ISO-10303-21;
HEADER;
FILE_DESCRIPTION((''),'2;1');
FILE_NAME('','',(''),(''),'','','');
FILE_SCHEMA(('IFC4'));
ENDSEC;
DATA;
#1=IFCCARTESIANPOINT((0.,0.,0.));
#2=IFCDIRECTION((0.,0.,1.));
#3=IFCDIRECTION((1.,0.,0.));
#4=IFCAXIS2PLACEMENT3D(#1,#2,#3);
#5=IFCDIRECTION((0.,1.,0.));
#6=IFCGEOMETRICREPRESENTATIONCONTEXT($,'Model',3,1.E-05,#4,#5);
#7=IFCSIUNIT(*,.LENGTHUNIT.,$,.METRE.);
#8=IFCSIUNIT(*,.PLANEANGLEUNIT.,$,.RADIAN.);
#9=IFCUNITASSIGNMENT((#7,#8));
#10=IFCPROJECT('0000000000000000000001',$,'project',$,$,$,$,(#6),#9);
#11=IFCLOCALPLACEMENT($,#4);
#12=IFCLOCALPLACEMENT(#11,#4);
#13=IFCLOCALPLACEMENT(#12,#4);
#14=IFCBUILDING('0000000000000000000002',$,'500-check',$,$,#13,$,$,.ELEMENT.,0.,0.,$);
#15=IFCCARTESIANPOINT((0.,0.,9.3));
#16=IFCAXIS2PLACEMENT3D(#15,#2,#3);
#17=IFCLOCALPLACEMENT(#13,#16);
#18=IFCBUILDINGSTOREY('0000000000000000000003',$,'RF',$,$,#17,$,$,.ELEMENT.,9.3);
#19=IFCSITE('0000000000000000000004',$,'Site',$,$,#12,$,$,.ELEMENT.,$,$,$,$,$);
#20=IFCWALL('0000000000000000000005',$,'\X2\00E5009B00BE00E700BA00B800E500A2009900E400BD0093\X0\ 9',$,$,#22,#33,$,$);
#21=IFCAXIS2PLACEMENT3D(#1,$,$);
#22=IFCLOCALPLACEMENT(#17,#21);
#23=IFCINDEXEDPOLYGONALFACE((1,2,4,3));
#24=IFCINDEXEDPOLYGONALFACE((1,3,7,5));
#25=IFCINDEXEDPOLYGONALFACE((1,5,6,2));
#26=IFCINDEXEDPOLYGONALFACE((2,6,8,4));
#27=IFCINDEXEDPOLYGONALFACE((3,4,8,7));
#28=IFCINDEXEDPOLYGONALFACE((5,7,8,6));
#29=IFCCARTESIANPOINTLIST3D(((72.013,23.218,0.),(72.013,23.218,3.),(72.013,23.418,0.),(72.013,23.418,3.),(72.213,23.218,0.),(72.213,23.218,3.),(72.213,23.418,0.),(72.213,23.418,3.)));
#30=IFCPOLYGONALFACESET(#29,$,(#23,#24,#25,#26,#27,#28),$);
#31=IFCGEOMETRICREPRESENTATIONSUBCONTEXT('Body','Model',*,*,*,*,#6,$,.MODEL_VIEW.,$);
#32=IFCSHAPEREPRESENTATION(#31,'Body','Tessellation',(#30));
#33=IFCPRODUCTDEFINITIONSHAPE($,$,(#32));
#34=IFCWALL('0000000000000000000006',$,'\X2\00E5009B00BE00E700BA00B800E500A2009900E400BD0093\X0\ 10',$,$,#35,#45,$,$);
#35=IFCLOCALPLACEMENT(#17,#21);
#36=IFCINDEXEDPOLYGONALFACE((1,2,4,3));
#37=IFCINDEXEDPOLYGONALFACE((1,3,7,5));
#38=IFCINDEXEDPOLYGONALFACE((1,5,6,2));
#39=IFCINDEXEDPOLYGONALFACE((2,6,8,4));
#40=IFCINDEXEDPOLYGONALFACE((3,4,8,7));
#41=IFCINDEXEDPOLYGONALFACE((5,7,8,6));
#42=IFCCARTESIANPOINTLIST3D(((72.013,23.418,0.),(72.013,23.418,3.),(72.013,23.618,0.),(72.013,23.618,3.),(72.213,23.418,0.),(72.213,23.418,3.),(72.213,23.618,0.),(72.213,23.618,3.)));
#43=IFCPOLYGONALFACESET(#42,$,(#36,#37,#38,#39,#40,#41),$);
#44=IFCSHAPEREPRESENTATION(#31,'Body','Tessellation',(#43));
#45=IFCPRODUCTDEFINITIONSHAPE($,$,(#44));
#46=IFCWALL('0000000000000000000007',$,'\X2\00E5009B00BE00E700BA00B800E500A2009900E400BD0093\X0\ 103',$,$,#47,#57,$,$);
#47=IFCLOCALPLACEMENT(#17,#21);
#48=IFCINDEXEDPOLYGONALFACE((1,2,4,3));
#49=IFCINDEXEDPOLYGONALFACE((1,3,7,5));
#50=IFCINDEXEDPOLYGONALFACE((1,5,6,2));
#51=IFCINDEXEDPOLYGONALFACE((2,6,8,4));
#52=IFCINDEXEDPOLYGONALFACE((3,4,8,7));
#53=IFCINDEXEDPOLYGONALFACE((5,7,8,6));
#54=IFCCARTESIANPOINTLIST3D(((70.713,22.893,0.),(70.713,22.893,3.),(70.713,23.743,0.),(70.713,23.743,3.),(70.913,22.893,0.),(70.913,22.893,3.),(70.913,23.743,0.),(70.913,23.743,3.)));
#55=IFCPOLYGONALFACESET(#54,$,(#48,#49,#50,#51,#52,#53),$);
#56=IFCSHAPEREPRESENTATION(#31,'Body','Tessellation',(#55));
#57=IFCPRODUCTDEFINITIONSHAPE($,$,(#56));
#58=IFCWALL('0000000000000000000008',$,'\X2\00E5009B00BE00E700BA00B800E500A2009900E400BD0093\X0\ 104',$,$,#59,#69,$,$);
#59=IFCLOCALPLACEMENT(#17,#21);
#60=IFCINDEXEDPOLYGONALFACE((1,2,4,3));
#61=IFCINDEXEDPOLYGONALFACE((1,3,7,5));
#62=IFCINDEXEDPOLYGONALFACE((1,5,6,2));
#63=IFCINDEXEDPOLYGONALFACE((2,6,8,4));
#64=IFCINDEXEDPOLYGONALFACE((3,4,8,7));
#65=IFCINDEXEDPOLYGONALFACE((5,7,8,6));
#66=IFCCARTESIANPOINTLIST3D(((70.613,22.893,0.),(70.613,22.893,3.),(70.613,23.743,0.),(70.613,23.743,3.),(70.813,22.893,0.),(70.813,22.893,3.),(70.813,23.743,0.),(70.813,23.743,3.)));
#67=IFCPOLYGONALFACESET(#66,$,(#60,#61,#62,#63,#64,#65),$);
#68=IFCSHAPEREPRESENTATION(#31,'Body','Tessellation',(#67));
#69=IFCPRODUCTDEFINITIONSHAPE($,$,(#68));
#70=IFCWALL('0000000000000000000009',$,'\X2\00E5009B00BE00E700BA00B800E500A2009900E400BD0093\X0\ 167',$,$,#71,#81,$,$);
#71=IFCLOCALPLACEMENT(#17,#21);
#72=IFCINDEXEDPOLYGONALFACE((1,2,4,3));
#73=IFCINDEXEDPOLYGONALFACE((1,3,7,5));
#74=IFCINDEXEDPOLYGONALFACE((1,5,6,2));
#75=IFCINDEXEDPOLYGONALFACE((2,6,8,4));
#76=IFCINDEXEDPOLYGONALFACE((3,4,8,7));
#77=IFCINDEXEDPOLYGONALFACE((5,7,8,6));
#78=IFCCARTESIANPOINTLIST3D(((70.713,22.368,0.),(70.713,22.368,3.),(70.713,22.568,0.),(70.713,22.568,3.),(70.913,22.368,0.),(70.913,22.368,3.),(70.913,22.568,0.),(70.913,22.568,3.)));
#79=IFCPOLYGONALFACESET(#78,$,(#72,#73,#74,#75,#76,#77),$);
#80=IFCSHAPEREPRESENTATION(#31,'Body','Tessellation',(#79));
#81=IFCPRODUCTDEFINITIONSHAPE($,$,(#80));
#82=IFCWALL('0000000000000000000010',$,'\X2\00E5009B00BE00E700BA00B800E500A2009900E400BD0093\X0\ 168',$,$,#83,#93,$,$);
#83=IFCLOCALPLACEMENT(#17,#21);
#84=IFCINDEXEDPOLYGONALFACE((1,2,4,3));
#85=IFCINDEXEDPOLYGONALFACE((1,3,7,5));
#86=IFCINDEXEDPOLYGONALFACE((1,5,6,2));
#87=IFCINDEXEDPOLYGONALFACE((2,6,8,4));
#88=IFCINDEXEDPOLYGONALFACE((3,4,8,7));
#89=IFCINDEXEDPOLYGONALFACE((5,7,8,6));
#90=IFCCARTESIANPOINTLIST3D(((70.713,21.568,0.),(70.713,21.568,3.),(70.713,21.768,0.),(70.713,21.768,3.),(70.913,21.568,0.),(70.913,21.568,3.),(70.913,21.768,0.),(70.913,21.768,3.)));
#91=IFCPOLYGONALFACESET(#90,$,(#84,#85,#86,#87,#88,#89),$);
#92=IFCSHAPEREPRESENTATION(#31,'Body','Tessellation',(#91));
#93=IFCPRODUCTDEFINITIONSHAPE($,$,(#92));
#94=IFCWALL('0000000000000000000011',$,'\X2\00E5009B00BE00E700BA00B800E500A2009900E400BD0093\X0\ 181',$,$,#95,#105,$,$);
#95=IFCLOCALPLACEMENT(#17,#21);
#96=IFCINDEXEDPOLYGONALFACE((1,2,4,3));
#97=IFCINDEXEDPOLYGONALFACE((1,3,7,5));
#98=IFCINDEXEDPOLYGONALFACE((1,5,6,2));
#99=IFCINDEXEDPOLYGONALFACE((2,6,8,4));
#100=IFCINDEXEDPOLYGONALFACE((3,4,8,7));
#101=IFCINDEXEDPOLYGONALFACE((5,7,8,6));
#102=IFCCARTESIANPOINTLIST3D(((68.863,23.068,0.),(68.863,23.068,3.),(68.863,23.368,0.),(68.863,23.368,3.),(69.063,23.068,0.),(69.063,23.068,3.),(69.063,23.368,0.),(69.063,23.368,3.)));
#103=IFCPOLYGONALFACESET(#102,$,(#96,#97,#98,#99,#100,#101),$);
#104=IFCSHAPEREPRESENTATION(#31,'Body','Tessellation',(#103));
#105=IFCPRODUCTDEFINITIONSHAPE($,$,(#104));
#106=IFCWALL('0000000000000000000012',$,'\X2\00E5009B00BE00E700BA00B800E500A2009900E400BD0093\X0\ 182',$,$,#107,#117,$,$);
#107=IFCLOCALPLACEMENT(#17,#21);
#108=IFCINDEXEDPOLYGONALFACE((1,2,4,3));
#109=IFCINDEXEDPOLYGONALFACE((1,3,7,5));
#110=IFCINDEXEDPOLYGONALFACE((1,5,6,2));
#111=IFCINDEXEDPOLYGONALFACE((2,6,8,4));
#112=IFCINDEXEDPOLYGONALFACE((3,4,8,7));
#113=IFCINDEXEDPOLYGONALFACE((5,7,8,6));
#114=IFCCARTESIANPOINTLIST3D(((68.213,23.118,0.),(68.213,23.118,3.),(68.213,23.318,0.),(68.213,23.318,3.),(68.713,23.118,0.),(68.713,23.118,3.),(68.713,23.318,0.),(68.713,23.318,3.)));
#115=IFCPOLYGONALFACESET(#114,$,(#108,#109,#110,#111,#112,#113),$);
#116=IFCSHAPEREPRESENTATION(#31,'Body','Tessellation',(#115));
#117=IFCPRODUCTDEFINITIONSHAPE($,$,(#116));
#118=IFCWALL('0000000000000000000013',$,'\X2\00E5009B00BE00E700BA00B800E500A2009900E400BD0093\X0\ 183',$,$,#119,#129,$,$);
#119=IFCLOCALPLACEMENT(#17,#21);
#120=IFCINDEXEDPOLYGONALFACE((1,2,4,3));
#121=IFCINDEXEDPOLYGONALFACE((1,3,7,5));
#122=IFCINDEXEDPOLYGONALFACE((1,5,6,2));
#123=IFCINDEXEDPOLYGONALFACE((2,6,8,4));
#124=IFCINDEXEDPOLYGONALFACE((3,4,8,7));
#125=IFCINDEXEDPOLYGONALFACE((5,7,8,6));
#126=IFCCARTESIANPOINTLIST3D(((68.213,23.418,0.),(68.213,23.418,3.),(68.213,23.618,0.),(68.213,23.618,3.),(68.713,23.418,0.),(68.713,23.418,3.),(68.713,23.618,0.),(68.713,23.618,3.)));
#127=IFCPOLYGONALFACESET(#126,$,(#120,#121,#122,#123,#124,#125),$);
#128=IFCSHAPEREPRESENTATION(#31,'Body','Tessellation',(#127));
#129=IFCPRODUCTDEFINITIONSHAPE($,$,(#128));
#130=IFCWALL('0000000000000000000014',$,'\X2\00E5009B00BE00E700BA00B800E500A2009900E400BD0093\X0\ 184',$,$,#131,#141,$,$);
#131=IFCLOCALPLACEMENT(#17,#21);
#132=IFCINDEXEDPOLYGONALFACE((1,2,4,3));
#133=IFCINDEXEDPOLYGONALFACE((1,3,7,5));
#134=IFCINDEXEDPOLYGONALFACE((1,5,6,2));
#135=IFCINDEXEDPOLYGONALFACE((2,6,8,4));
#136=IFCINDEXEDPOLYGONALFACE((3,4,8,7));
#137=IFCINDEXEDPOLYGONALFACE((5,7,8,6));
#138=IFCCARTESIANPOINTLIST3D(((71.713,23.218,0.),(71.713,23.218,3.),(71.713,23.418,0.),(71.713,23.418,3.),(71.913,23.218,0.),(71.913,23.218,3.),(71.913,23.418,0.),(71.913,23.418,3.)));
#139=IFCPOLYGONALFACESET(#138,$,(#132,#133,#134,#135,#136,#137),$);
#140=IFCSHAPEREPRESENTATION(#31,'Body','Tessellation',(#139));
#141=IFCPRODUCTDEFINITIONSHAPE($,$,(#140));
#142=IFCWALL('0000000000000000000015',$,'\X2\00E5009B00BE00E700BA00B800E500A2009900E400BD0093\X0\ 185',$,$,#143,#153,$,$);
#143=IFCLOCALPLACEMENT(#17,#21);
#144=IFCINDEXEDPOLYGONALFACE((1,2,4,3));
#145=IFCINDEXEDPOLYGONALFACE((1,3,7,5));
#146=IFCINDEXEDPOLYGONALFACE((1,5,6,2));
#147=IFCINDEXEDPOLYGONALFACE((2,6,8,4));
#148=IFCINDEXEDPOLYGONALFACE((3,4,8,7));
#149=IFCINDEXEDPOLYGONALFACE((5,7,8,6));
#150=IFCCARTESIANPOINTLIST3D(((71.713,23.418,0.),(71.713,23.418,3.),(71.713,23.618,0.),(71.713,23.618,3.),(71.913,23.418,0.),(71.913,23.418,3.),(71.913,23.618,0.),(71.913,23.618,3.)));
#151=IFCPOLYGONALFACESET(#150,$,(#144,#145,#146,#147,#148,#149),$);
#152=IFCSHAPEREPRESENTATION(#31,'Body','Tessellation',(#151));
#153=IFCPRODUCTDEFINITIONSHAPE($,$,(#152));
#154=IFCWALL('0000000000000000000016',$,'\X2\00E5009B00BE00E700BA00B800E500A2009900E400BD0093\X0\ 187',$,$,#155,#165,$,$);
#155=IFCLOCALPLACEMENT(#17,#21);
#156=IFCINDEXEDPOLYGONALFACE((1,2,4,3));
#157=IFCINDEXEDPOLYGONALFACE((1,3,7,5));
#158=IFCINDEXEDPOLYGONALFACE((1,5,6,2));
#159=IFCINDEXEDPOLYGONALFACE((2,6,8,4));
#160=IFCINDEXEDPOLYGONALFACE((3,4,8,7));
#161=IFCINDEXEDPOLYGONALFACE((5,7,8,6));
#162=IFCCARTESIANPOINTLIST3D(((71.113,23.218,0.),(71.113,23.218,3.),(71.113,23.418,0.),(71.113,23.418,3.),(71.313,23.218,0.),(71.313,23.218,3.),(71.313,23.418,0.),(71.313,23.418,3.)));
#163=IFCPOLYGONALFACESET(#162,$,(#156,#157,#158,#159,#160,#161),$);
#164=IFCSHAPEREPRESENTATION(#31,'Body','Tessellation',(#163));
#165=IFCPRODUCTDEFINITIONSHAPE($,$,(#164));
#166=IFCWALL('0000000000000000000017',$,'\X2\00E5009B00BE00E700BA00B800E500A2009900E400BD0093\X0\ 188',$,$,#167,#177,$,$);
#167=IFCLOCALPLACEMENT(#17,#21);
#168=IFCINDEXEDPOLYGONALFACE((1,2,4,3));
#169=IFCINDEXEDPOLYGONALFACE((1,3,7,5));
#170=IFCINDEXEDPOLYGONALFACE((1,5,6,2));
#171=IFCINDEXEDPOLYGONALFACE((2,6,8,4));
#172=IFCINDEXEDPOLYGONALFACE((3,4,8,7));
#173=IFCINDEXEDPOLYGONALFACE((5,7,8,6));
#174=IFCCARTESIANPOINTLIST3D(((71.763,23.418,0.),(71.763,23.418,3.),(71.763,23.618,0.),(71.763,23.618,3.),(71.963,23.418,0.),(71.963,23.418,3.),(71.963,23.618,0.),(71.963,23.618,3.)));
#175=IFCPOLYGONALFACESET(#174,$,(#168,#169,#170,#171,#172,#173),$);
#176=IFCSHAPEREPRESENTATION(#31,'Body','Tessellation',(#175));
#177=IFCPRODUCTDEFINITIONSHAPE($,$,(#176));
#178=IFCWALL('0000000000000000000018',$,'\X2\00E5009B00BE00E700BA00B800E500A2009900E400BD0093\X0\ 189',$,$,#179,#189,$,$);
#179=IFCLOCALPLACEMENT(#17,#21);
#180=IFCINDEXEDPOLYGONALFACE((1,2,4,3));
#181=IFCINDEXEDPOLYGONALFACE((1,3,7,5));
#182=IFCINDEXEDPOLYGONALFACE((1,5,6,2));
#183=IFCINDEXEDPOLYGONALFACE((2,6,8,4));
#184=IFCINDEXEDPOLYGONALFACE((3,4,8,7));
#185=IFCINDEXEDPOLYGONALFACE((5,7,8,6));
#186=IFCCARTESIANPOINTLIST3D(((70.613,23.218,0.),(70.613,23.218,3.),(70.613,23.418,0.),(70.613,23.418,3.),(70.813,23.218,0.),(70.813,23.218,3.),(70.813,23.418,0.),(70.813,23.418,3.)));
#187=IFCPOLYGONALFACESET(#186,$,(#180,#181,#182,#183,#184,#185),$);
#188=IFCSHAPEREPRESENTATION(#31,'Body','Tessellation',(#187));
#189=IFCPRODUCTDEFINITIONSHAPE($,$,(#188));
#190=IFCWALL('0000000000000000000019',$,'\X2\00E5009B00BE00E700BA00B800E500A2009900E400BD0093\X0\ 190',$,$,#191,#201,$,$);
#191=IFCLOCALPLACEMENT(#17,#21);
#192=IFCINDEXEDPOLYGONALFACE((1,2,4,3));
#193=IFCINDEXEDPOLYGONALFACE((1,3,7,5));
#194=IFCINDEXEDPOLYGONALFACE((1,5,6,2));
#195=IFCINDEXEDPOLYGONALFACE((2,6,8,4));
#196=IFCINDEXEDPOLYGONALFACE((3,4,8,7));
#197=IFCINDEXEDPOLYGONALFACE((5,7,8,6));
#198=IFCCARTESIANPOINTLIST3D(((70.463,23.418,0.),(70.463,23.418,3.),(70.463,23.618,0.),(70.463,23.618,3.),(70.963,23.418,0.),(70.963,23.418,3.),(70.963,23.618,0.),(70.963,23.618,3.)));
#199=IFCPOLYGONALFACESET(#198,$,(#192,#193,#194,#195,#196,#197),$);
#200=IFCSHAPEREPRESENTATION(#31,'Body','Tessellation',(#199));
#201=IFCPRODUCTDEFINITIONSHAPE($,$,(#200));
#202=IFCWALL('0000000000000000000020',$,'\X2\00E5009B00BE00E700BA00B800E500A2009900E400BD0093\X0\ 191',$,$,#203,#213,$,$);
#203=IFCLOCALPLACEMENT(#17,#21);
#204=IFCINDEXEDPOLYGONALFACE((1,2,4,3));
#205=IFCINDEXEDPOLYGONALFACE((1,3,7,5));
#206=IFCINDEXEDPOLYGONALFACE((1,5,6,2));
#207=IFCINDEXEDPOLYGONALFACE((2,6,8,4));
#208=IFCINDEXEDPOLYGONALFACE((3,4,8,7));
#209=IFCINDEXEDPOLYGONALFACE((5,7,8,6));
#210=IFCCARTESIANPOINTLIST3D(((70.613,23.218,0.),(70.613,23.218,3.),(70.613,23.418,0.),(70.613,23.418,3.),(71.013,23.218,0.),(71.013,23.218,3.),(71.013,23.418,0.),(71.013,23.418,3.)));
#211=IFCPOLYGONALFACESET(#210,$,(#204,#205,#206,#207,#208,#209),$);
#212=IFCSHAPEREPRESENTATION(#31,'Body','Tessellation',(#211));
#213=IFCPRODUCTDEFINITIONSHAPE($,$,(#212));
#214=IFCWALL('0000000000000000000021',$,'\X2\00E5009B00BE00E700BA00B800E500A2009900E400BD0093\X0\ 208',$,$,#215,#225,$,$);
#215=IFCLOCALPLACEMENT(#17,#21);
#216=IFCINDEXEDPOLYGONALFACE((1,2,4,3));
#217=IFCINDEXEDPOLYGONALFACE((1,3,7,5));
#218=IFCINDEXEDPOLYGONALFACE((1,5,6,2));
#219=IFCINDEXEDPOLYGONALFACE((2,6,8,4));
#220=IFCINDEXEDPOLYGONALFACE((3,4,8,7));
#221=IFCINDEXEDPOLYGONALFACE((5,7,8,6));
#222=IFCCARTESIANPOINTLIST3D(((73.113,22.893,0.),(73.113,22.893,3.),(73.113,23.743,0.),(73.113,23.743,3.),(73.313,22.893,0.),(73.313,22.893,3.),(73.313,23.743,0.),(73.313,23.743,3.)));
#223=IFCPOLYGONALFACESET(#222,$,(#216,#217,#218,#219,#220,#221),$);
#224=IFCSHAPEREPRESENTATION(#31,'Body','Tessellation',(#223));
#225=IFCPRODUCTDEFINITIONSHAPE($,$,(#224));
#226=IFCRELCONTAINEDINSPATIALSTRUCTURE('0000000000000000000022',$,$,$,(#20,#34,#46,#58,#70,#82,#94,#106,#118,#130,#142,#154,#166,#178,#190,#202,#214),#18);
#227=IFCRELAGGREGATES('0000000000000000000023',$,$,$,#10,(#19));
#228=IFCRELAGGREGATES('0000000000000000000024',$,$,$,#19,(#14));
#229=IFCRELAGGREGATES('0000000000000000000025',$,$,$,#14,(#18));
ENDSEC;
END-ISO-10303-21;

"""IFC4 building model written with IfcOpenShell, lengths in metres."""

from ifc_helpers import new_model, si_unit, direction, frame, frame_2d, origin_with_axes, place, context, subcontext, project, spatial, rectangle, extrude, element, save


model = new_model("IFC4")

# Units and contexts
model_context = context("Model", 3, precision=1e-05, world=origin_with_axes(), true_north=direction((0.0, 1.0, 0.0)))
body_context = subcontext(model_context, "Body", "Model", "MODEL_VIEW")
ifc_project = project(units=[si_unit("LENGTHUNIT", "METRE"), si_unit("PLANEANGLEUNIT", "RADIAN")], contexts=[model_context])

# Site, building, storey
placement = place(None, origin_with_axes())
site_placement = place(placement, origin_with_axes())
site = spatial("IfcSite", under=ifc_project, at=site_placement, Name="Site", CompositionType="ELEMENT")
building_placement = place(site_placement, origin_with_axes())
building = spatial("IfcBuilding", under=site, at=building_placement, Name="500-check", CompositionType="ELEMENT", ElevationOfRefHeight=0.0, ElevationOfTerrain=0.0)
storey_placement = place(building_placement, frame((0.0, 0.0, 9.3), z_axis=(0.0, 0.0, 1.0), x_axis=(1.0, 0.0, 0.0)))
storey = spatial("IfcBuildingStorey", under=building, at=storey_placement, Name="RF", CompositionType="ELEMENT", Elevation=9.3)

# Walls
for number, where, z_axis, x_axis, name in (
    (1, (72.113, 23.318, 0.0), (0.0, 0.0, 1.0), (-1.0, 0.0, 0.0), "å\u009b¾çº¸å¢\u0099ä½\u0093 9"),
    (2, (72.113, 23.518, 0.0), (0.0, 0.0, 1.0), (-1.0, 0.0, 0.0), "å\u009b¾çº¸å¢\u0099ä½\u0093 10"),
):
    element("IfcWall", number, at=place(storey_placement, frame(where, z_axis=z_axis, x_axis=x_axis)), inside=storey, Name=name, context=body_context, shape_type="SweptSolid", body=[
        extrude(rectangle(XDim=0.2, YDim=0.2, at=frame_2d((0.0, 0.0), x_axis=(1.0, 0.0, 0.0))), frame((0.0, 0.0, 0.0), z_axis=(0.0, 0.0, 1.0)), (0.0, 0.0, 1.0), 3.0),
    ])
for number, where, z_axis, x_axis, name in (
    (3, (70.813, 23.318, 0.0), (0.0, 0.0, 1.0), (0.0, -1.0, 0.0), "å\u009b¾çº¸å¢\u0099ä½\u0093 103"),
    (4, (70.713, 23.318, 0.0), (0.0, 0.0, 1.0), (0.0, -1.0, 0.0), "å\u009b¾çº¸å¢\u0099ä½\u0093 104"),
):
    element("IfcWall", number, at=place(storey_placement, frame(where, z_axis=z_axis, x_axis=x_axis)), inside=storey, Name=name, context=body_context, shape_type="SweptSolid", body=[
        extrude(rectangle(XDim=0.85, YDim=0.2, at=frame_2d((0.0, 0.0), x_axis=(1.0, 0.0, 0.0))), frame((0.0, 0.0, 0.0), z_axis=(0.0, 0.0, 1.0)), (0.0, 0.0, 1.0), 3.0),
    ])
for number, where, z_axis, x_axis, name in (
    (5, (70.813, 22.468, 0.0), (0.0, 0.0, 1.0), (-1.0, 0.0, 0.0), "å\u009b¾çº¸å¢\u0099ä½\u0093 167"),
    (6, (70.813, 21.668, 0.0), (0.0, 0.0, 1.0), (0.0, -1.0, 0.0), "å\u009b¾çº¸å¢\u0099ä½\u0093 168"),
):
    element("IfcWall", number, at=place(storey_placement, frame(where, z_axis=z_axis, x_axis=x_axis)), inside=storey, Name=name, context=body_context, shape_type="SweptSolid", body=[
        extrude(rectangle(XDim=0.2, YDim=0.2, at=frame_2d((0.0, 0.0), x_axis=(1.0, 0.0, 0.0))), frame((0.0, 0.0, 0.0), z_axis=(0.0, 0.0, 1.0)), (0.0, 0.0, 1.0), 3.0),
    ])
wall_1_placement = place(storey_placement, frame((68.963, 23.218, 0.0), z_axis=(0.0, 0.0, 1.0), x_axis=(0.0, 1.0, 0.0)))
element("IfcWall", 7, at=wall_1_placement, inside=storey, Name="å\u009b¾çº¸å¢\u0099ä½\u0093 181", context=body_context, shape_type="SweptSolid", body=[
    extrude(rectangle(XDim=0.3, YDim=0.2, at=frame_2d((0.0, 0.0), x_axis=(1.0, 0.0, 0.0))), frame((0.0, 0.0, 0.0), z_axis=(0.0, 0.0, 1.0)), (0.0, 0.0, 1.0), 3.0),
])
for number, where, z_axis, x_axis, name in (
    (8, (68.463, 23.218, 0.0), (0.0, 0.0, 1.0), (1.0, 0.0, 0.0), "å\u009b¾çº¸å¢\u0099ä½\u0093 182"),
    (9, (68.463, 23.518, 0.0), (0.0, 0.0, 1.0), (1.0, 0.0, 0.0), "å\u009b¾çº¸å¢\u0099ä½\u0093 183"),
):
    element("IfcWall", number, at=place(storey_placement, frame(where, z_axis=z_axis, x_axis=x_axis)), inside=storey, Name=name, context=body_context, shape_type="SweptSolid", body=[
        extrude(rectangle(XDim=0.5, YDim=0.2, at=frame_2d((0.0, 0.0), x_axis=(1.0, 0.0, 0.0))), frame((0.0, 0.0, 0.0), z_axis=(0.0, 0.0, 1.0)), (0.0, 0.0, 1.0), 3.0),
    ])
for number, where, z_axis, x_axis, name in (
    (10, (71.813, 23.318, 0.0), (0.0, 0.0, 1.0), (1.0, 0.0, 0.0), "å\u009b¾çº¸å¢\u0099ä½\u0093 184"),
    (11, (71.813, 23.518, 0.0), (0.0, 0.0, 1.0), (1.0, 0.0, 0.0), "å\u009b¾çº¸å¢\u0099ä½\u0093 185"),
    (12, (71.213, 23.318, 0.0), (0.0, 0.0, 1.0), (0.0, 1.0, 0.0), "å\u009b¾çº¸å¢\u0099ä½\u0093 187"),
    (13, (71.863, 23.518, 0.0), (0.0, 0.0, 1.0), (1.0, 0.0, 0.0), "å\u009b¾çº¸å¢\u0099ä½\u0093 188"),
    (14, (70.713, 23.318, 0.0), (0.0, 0.0, 1.0), (0.0, 1.0, 0.0), "å\u009b¾çº¸å¢\u0099ä½\u0093 189"),
):
    element("IfcWall", number, at=place(storey_placement, frame(where, z_axis=z_axis, x_axis=x_axis)), inside=storey, Name=name, context=body_context, shape_type="SweptSolid", body=[
        extrude(rectangle(XDim=0.2, YDim=0.2, at=frame_2d((0.0, 0.0), x_axis=(1.0, 0.0, 0.0))), frame((0.0, 0.0, 0.0), z_axis=(0.0, 0.0, 1.0)), (0.0, 0.0, 1.0), 3.0),
    ])
wall_2_placement = place(storey_placement, frame((70.713, 23.518, 0.0), z_axis=(0.0, 0.0, 1.0), x_axis=(1.0, 0.0, 0.0)))
element("IfcWall", 15, at=wall_2_placement, inside=storey, Name="å\u009b¾çº¸å¢\u0099ä½\u0093 190", context=body_context, shape_type="SweptSolid", body=[
    extrude(rectangle(XDim=0.5, YDim=0.2, at=frame_2d((0.0, 0.0), x_axis=(1.0, 0.0, 0.0))), frame((0.0, 0.0, 0.0), z_axis=(0.0, 0.0, 1.0)), (0.0, 0.0, 1.0), 3.0),
])
wall_3_placement = place(storey_placement, frame((70.813, 23.318, 0.0), z_axis=(0.0, 0.0, 1.0), x_axis=(1.0, 0.0, 0.0)))
element("IfcWall", 16, at=wall_3_placement, inside=storey, Name="å\u009b¾çº¸å¢\u0099ä½\u0093 191", context=body_context, shape_type="SweptSolid", body=[
    extrude(rectangle(XDim=0.4, YDim=0.2, at=frame_2d((0.0, 0.0), x_axis=(1.0, 0.0, 0.0))), frame((0.0, 0.0, 0.0), z_axis=(0.0, 0.0, 1.0)), (0.0, 0.0, 1.0), 3.0),
])
for number, where, z_axis, x_axis, name in (
    (17, (73.213, 23.318, 0.0), (0.0, 0.0, 1.0), (0.0, -1.0, 0.0), "å\u009b¾çº¸å¢\u0099ä½\u0093 208"),
):
    element("IfcWall", number, at=place(storey_placement, frame(where, z_axis=z_axis, x_axis=x_axis)), inside=storey, Name=name, context=body_context, shape_type="SweptSolid", body=[
        extrude(rectangle(XDim=0.85, YDim=0.2, at=frame_2d((0.0, 0.0), x_axis=(1.0, 0.0, 0.0))), frame((0.0, 0.0, 0.0), z_axis=(0.0, 0.0, 1.0)), (0.0, 0.0, 1.0), 3.0),
    ])

save(model, "model.ifc")
